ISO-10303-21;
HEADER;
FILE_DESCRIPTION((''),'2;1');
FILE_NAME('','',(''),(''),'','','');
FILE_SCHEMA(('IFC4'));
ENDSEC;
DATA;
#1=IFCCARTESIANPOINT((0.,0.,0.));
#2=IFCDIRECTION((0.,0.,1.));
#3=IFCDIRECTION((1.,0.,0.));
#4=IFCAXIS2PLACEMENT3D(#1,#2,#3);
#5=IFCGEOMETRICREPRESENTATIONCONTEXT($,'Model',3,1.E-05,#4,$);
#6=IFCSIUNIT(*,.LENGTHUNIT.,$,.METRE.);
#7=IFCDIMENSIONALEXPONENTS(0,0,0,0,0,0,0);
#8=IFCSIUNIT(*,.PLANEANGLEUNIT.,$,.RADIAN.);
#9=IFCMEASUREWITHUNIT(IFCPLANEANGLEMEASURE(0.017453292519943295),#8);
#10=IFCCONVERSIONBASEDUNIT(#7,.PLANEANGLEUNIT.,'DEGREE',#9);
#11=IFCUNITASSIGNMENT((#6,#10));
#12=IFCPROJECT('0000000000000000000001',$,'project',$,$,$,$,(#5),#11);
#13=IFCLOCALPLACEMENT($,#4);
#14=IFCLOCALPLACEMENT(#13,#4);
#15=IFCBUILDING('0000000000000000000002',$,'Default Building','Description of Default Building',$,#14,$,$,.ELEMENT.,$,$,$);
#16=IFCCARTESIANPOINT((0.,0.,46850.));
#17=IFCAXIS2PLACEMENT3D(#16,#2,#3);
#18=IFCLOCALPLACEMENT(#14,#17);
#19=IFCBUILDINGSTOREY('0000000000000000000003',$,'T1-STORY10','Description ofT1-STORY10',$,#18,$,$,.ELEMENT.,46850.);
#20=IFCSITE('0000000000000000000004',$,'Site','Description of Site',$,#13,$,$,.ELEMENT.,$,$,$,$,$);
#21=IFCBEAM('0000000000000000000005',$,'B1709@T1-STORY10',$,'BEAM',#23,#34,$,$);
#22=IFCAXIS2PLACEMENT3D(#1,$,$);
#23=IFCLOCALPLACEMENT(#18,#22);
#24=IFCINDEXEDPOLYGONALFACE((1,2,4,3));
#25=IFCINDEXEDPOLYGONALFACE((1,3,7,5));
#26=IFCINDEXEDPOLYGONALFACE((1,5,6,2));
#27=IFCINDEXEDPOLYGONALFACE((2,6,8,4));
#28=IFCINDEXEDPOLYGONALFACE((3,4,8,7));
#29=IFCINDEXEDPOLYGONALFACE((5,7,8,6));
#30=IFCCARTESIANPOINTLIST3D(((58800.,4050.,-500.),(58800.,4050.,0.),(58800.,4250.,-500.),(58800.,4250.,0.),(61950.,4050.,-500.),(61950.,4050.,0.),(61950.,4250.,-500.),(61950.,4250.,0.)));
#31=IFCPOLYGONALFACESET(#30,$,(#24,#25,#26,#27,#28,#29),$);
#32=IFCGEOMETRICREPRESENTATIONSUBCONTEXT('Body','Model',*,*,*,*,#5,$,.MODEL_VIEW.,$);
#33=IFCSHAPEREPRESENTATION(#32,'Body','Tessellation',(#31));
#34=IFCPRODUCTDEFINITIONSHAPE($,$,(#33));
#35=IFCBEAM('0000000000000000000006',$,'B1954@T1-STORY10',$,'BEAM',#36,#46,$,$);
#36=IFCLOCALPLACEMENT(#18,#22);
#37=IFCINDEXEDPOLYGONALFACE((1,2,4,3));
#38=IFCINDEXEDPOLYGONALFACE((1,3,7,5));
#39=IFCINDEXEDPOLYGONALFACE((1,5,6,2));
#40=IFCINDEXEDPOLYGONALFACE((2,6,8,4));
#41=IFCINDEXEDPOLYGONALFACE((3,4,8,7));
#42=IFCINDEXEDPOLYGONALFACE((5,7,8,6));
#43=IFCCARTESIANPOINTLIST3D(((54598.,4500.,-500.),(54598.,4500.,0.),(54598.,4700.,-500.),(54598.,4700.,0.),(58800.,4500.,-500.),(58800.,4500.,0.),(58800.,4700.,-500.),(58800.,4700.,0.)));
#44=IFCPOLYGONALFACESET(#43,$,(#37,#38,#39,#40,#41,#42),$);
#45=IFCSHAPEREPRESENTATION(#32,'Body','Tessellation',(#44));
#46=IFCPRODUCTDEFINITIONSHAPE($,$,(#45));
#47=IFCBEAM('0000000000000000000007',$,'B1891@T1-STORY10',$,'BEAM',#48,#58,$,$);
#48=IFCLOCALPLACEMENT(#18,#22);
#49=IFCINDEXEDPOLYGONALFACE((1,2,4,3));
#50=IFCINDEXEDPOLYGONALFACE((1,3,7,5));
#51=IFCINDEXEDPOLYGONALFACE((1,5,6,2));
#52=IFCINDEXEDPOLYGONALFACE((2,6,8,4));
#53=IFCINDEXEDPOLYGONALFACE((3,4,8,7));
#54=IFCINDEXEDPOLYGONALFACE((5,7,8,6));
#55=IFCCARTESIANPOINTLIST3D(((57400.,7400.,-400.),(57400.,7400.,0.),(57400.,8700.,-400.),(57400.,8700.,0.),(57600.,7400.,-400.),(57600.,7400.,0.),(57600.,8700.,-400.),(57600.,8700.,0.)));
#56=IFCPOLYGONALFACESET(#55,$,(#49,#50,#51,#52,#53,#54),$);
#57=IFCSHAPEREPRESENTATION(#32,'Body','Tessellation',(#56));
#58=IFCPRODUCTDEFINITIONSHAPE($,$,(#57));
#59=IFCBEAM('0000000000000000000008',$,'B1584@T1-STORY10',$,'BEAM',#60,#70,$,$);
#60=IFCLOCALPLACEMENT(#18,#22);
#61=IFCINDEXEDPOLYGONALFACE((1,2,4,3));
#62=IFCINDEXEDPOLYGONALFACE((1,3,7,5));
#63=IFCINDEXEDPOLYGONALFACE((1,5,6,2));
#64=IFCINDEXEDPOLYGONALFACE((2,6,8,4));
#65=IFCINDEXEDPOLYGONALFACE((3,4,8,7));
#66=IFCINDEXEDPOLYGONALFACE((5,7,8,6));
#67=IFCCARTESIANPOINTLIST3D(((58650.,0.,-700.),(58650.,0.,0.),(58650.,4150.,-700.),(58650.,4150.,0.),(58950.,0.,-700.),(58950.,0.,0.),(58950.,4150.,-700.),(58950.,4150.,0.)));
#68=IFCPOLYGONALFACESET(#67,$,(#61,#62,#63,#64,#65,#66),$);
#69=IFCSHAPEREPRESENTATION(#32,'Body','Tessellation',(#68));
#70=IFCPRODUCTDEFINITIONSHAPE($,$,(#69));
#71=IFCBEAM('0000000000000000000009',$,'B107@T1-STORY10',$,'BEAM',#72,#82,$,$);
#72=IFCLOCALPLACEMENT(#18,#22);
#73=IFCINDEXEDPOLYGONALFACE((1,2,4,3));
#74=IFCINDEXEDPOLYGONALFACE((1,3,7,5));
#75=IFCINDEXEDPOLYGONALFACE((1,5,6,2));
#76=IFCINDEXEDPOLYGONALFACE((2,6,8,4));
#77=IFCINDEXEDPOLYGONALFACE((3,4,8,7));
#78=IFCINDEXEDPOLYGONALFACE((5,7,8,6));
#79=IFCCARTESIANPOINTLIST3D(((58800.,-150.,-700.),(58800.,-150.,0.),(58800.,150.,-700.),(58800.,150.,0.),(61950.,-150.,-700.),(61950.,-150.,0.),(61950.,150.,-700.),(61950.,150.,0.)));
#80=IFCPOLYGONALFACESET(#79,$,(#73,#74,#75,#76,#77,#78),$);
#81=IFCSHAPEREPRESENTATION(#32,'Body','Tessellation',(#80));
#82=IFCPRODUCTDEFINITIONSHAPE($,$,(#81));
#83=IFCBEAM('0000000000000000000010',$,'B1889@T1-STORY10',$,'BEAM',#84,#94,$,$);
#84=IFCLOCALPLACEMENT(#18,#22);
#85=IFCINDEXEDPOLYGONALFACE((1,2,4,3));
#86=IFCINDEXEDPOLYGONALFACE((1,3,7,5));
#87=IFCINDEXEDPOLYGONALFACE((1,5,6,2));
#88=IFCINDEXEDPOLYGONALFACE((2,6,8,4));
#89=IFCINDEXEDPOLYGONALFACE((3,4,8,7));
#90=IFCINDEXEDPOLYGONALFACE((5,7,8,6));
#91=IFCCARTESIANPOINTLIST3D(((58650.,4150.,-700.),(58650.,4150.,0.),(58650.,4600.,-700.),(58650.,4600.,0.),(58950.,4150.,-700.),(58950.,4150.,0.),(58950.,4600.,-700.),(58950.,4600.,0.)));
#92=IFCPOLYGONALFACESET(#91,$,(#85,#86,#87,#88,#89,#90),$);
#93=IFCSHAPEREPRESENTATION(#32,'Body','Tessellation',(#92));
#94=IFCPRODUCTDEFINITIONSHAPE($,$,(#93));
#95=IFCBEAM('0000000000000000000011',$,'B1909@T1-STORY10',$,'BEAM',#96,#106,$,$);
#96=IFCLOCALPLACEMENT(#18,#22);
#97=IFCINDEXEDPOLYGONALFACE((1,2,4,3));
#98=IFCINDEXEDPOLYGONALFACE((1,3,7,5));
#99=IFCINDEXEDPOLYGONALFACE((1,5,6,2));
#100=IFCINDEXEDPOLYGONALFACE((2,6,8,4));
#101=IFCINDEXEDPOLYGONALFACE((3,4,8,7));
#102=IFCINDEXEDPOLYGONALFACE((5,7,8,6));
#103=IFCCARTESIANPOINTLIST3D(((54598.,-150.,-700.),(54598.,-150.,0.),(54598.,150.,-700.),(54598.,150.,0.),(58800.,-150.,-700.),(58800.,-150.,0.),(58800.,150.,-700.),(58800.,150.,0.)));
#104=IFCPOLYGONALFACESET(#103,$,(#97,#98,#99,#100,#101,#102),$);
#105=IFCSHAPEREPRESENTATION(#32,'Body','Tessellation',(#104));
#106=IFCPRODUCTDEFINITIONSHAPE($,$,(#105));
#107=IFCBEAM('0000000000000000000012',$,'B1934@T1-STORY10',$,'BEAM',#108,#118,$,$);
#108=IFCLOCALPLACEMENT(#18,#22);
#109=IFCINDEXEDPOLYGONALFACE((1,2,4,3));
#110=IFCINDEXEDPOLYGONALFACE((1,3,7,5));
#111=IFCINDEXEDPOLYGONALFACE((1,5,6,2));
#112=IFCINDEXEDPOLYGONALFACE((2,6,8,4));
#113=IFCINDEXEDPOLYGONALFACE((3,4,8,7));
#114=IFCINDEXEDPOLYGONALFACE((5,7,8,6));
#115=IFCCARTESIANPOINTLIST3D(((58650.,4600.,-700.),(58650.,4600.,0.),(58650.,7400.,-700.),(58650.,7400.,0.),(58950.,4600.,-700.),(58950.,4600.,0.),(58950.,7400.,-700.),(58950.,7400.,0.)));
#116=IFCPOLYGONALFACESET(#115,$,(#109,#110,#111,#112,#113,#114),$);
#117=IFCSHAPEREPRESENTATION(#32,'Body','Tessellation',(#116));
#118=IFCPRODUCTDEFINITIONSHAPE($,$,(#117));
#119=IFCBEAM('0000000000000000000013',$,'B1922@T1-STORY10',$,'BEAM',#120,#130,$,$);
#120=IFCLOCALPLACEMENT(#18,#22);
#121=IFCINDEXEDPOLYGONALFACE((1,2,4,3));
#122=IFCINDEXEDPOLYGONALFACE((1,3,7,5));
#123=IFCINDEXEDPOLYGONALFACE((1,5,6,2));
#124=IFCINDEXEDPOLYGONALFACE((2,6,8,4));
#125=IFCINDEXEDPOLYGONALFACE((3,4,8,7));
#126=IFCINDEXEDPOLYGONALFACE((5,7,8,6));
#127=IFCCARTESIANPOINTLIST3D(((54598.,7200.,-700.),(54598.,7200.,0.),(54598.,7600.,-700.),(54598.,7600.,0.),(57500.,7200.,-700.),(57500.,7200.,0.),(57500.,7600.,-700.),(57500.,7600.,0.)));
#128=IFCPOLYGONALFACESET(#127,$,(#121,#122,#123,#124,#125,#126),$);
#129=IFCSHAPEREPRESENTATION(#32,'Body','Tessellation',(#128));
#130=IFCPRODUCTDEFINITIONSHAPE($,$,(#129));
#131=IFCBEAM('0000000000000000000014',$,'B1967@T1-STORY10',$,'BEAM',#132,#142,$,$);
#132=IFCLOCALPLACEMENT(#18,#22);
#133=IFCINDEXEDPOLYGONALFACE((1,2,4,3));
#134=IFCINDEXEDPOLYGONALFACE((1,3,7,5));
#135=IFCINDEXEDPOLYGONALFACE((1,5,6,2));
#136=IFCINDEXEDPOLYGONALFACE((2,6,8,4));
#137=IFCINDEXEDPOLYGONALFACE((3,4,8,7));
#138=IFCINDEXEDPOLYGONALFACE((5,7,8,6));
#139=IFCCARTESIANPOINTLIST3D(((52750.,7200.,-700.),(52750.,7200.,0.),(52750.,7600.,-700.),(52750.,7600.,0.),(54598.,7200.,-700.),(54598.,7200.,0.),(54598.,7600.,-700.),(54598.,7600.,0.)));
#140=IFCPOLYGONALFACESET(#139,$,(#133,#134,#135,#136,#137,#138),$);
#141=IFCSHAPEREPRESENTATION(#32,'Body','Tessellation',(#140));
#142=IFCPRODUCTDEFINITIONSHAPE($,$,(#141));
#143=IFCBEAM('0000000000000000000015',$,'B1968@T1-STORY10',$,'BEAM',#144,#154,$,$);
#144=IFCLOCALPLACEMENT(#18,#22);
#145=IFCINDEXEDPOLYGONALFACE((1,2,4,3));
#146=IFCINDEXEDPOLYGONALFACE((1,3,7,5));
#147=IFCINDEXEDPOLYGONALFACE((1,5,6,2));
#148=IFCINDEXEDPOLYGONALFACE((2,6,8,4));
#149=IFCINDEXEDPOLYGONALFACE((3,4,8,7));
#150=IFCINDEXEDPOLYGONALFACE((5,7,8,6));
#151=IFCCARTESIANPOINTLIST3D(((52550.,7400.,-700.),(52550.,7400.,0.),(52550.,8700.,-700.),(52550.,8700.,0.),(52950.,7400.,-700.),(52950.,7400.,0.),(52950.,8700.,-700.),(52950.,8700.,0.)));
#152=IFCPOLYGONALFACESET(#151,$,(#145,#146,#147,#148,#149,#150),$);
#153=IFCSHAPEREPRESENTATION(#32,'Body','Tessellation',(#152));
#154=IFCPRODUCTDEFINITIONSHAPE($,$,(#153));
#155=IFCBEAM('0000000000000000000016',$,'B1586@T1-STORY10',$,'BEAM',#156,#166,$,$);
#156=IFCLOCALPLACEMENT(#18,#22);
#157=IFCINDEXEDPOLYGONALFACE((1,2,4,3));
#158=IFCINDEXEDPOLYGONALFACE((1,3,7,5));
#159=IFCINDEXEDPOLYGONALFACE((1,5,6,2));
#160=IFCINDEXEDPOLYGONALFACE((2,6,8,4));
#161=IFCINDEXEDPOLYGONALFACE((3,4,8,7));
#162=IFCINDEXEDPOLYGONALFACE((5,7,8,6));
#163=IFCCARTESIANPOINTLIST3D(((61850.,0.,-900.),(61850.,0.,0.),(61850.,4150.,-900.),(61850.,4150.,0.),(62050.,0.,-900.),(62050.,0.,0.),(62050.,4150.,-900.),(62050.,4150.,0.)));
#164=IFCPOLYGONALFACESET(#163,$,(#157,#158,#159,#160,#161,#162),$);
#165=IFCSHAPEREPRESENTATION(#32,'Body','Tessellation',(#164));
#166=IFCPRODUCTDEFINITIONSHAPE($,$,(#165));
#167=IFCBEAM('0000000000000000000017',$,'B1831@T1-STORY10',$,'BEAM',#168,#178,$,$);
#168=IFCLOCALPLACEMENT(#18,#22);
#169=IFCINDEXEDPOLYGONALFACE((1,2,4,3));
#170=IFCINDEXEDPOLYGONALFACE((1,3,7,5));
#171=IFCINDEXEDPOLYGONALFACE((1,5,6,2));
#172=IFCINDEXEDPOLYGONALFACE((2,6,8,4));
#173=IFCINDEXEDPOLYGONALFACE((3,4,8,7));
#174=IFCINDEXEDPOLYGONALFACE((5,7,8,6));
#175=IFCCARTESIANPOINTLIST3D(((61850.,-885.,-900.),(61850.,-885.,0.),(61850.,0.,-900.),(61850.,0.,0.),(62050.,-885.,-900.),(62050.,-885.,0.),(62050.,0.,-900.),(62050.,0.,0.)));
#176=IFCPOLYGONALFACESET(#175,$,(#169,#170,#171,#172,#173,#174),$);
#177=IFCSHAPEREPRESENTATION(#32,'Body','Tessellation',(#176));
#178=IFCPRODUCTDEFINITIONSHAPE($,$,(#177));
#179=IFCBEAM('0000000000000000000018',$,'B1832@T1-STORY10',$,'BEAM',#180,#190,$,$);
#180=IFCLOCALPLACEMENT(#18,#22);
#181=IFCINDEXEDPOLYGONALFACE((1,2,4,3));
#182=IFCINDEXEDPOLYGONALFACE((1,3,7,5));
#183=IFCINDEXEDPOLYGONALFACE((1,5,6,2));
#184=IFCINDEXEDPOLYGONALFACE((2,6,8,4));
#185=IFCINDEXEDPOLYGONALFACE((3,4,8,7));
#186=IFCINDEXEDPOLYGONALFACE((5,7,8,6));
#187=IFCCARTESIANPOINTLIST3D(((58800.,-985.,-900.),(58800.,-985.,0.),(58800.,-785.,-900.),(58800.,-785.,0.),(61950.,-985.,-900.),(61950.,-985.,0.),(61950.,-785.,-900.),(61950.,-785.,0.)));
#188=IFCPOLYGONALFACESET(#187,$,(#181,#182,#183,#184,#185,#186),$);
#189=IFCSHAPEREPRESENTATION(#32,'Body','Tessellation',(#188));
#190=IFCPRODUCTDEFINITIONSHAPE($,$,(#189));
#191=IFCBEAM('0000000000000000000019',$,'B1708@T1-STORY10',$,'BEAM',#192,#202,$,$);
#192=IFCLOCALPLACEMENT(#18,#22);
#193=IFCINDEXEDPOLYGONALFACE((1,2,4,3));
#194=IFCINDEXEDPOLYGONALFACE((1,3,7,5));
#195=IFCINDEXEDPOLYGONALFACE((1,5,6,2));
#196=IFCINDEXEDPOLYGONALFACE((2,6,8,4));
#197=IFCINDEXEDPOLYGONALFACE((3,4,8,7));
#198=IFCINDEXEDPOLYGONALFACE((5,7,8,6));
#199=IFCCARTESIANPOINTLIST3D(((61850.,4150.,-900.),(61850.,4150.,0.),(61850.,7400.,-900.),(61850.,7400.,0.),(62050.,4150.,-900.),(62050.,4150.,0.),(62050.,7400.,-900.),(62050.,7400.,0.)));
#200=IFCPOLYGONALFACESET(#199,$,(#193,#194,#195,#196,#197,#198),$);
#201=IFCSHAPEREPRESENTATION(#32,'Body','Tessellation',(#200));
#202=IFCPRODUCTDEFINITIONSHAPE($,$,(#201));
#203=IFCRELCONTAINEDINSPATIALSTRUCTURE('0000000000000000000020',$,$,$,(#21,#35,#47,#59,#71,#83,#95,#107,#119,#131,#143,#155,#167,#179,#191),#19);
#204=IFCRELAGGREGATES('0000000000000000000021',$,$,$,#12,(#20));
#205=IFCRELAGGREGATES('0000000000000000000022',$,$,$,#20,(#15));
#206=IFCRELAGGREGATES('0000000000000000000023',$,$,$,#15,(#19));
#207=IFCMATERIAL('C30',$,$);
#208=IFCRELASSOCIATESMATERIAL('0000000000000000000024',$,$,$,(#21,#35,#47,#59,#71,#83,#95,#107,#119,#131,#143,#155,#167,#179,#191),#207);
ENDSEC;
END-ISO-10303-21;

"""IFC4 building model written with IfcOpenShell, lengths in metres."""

from ifc_helpers import new_model, entity, si_unit, converted_unit, frame, origin_with_axes, place, context, subcontext, project, spatial, rectangle, extrude, material, element, save


model = new_model("IFC4")

# Units and contexts
model_context = context("Model", 3, precision=1e-05, world=origin_with_axes())
body_context = subcontext(model_context, "Body", "Model", "MODEL_VIEW")
ifc_project = project(units=[si_unit("LENGTHUNIT", "METRE"), converted_unit("PLANEANGLEUNIT", "DEGREE", entity("IfcPlaneAngleMeasure", 0.017453292519943295), si_unit("PLANEANGLEUNIT", "RADIAN"), dimensions=[0, 0, 0, 0, 0, 0, 0])], contexts=[model_context])

# Site, building, storey
site_placement = place(None, origin_with_axes())
site = spatial("IfcSite", under=ifc_project, at=site_placement, Name="Site", Description="Description of Site", CompositionType="ELEMENT")
building_placement = place(site_placement, origin_with_axes())
building = spatial("IfcBuilding", under=site, at=building_placement, Name="Default Building", Description="Description of Default Building", CompositionType="ELEMENT")
storey_placement = place(building_placement, frame((0.0, 0.0, 46850.0), z_axis=(0.0, 0.0, 1.0), x_axis=(1.0, 0.0, 0.0)))
storey = spatial("IfcBuildingStorey", under=building, at=storey_placement, Name="T1-STORY10", Description="Description ofT1-STORY10", CompositionType="ELEMENT", Elevation=46850.0)

# Beams
ifc_material_1 = material(Name="C30")
beam_1_placement = place(storey_placement, frame((58800.0, 4150.0, -250.0), z_axis=(1.0, 0.0, 0.0), x_axis=(0.0, 1.0, 0.0)))
element("IfcBeam", 1, at=beam_1_placement, inside=storey, material=ifc_material_1, Name="B1709@T1-STORY10", ObjectType="BEAM", context=body_context, shape_type="SweptSolid", body=[
    extrude(rectangle(XDim=200.0, YDim=500.0), origin_with_axes(), (0.0, 0.0, 1.0), 3150.0),
])
beam_2_placement = place(storey_placement, frame((54598.0, 4600.0, -250.0), z_axis=(1.0, 0.0, 0.0), x_axis=(0.0, 1.0, 0.0)))
element("IfcBeam", 2, at=beam_2_placement, inside=storey, material=ifc_material_1, Name="B1954@T1-STORY10", ObjectType="BEAM", context=body_context, shape_type="SweptSolid", body=[
    extrude(rectangle(XDim=200.0, YDim=500.0), origin_with_axes(), (0.0, 0.0, 1.0), 4202.0),
])
beam_3_placement = place(storey_placement, frame((57500.0, 7400.0, -200.0), z_axis=(0.0, 1.0, 0.0), x_axis=(-1.0, 0.0, 0.0)))
element("IfcBeam", 3, at=beam_3_placement, inside=storey, material=ifc_material_1, Name="B1891@T1-STORY10", ObjectType="BEAM", context=body_context, shape_type="SweptSolid", body=[
    extrude(rectangle(XDim=200.0, YDim=400.0), origin_with_axes(), (0.0, 0.0, 1.0), 1300.0),
])
beam_4_placement = place(storey_placement, frame((58800.0, 0.0, -350.0), z_axis=(0.0, 1.0, 0.0), x_axis=(-1.0, 0.0, 0.0)))
element("IfcBeam", 4, at=beam_4_placement, inside=storey, material=ifc_material_1, Name="B1584@T1-STORY10", ObjectType="BEAM", context=body_context, shape_type="SweptSolid", body=[
    extrude(rectangle(XDim=300.0, YDim=700.0), origin_with_axes(), (0.0, 0.0, 1.0), 4150.0),
])
beam_5_placement = place(storey_placement, frame((58800.0, 0.0, -350.0), z_axis=(1.0, 0.0, 0.0), x_axis=(0.0, 1.0, 0.0)))
element("IfcBeam", 5, at=beam_5_placement, inside=storey, material=ifc_material_1, Name="B107@T1-STORY10", ObjectType="BEAM", context=body_context, shape_type="SweptSolid", body=[
    extrude(rectangle(XDim=300.0, YDim=700.0), origin_with_axes(), (0.0, 0.0, 1.0), 3150.0),
])
beam_6_placement = place(storey_placement, frame((58800.0, 4150.0, -350.0), z_axis=(0.0, 1.0, 0.0), x_axis=(-1.0, 0.0, 0.0)))
element("IfcBeam", 6, at=beam_6_placement, inside=storey, material=ifc_material_1, Name="B1889@T1-STORY10", ObjectType="BEAM", context=body_context, shape_type="SweptSolid", body=[
    extrude(rectangle(XDim=300.0, YDim=700.0), origin_with_axes(), (0.0, 0.0, 1.0), 450.0),
])
beam_7_placement = place(storey_placement, frame((54598.0, 0.0, -350.0), z_axis=(1.0, 0.0, 0.0), x_axis=(0.0, 1.0, 0.0)))
element("IfcBeam", 7, at=beam_7_placement, inside=storey, material=ifc_material_1, Name="B1909@T1-STORY10", ObjectType="BEAM", context=body_context, shape_type="SweptSolid", body=[
    extrude(rectangle(XDim=300.0, YDim=700.0), origin_with_axes(), (0.0, 0.0, 1.0), 4202.0),
])
beam_8_placement = place(storey_placement, frame((58800.0, 4600.0, -350.0), z_axis=(0.0, 1.0, 0.0), x_axis=(-1.0, 0.0, 0.0)))
element("IfcBeam", 8, at=beam_8_placement, inside=storey, material=ifc_material_1, Name="B1934@T1-STORY10", ObjectType="BEAM", context=body_context, shape_type="SweptSolid", body=[
    extrude(rectangle(XDim=300.0, YDim=700.0), origin_with_axes(), (0.0, 0.0, 1.0), 2800.0),
])
beam_9_placement = place(storey_placement, frame((54598.0, 7400.0, -350.0), z_axis=(1.0, 0.0, 0.0), x_axis=(0.0, 1.0, 0.0)))
element("IfcBeam", 9, at=beam_9_placement, inside=storey, material=ifc_material_1, Name="B1922@T1-STORY10", ObjectType="BEAM", context=body_context, shape_type="SweptSolid", body=[
    extrude(rectangle(XDim=400.0, YDim=700.0), origin_with_axes(), (0.0, 0.0, 1.0), 2902.0),
])
beam_10_placement = place(storey_placement, frame((52750.0, 7400.0, -350.0), z_axis=(1.0, 0.0, 0.0), x_axis=(0.0, 1.0, 0.0)))
element("IfcBeam", 10, at=beam_10_placement, inside=storey, material=ifc_material_1, Name="B1967@T1-STORY10", ObjectType="BEAM", context=body_context, shape_type="SweptSolid", body=[
    extrude(rectangle(XDim=400.0, YDim=700.0), origin_with_axes(), (0.0, 0.0, 1.0), 1848.0),
])
beam_11_placement = place(storey_placement, frame((52750.0, 7400.0, -350.0), z_axis=(0.0, 1.0, 0.0), x_axis=(-1.0, 0.0, 0.0)))
element("IfcBeam", 11, at=beam_11_placement, inside=storey, material=ifc_material_1, Name="B1968@T1-STORY10", ObjectType="BEAM", context=body_context, shape_type="SweptSolid", body=[
    extrude(rectangle(XDim=400.0, YDim=700.0), origin_with_axes(), (0.0, 0.0, 1.0), 1300.0),
])
beam_12_placement = place(storey_placement, frame((61950.0, 0.0, -450.0), z_axis=(0.0, 1.0, 0.0), x_axis=(-1.0, 0.0, 0.0)))
element("IfcBeam", 12, at=beam_12_placement, inside=storey, material=ifc_material_1, Name="B1586@T1-STORY10", ObjectType="BEAM", context=body_context, shape_type="SweptSolid", body=[
    extrude(rectangle(XDim=200.0, YDim=900.0), origin_with_axes(), (0.0, 0.0, 1.0), 4150.0),
])
beam_13_placement = place(storey_placement, frame((61950.0, -885.0, -450.0), z_axis=(0.0, 1.0, 0.0), x_axis=(-1.0, 0.0, 0.0)))
element("IfcBeam", 13, at=beam_13_placement, inside=storey, material=ifc_material_1, Name="B1831@T1-STORY10", ObjectType="BEAM", context=body_context, shape_type="SweptSolid", body=[
    extrude(rectangle(XDim=200.0, YDim=900.0), origin_with_axes(), (0.0, 0.0, 1.0), 885.0),
])
beam_14_placement = place(storey_placement, frame((58800.0, -885.0, -450.0), z_axis=(1.0, 0.0, 0.0), x_axis=(0.0, 1.0, 0.0)))
element("IfcBeam", 14, at=beam_14_placement, inside=storey, material=ifc_material_1, Name="B1832@T1-STORY10", ObjectType="BEAM", context=body_context, shape_type="SweptSolid", body=[
    extrude(rectangle(XDim=200.0, YDim=900.0), origin_with_axes(), (0.0, 0.0, 1.0), 3150.0),
])
beam_15_placement = place(storey_placement, frame((61950.0, 4150.0, -450.0), z_axis=(0.0, 1.0, 0.0), x_axis=(-1.0, 0.0, 0.0)))
element("IfcBeam", 15, at=beam_15_placement, inside=storey, material=ifc_material_1, Name="B1708@T1-STORY10", ObjectType="BEAM", context=body_context, shape_type="SweptSolid", body=[
    extrude(rectangle(XDim=200.0, YDim=900.0), origin_with_axes(), (0.0, 0.0, 1.0), 3250.0),
])

save(model, "model.ifc")
